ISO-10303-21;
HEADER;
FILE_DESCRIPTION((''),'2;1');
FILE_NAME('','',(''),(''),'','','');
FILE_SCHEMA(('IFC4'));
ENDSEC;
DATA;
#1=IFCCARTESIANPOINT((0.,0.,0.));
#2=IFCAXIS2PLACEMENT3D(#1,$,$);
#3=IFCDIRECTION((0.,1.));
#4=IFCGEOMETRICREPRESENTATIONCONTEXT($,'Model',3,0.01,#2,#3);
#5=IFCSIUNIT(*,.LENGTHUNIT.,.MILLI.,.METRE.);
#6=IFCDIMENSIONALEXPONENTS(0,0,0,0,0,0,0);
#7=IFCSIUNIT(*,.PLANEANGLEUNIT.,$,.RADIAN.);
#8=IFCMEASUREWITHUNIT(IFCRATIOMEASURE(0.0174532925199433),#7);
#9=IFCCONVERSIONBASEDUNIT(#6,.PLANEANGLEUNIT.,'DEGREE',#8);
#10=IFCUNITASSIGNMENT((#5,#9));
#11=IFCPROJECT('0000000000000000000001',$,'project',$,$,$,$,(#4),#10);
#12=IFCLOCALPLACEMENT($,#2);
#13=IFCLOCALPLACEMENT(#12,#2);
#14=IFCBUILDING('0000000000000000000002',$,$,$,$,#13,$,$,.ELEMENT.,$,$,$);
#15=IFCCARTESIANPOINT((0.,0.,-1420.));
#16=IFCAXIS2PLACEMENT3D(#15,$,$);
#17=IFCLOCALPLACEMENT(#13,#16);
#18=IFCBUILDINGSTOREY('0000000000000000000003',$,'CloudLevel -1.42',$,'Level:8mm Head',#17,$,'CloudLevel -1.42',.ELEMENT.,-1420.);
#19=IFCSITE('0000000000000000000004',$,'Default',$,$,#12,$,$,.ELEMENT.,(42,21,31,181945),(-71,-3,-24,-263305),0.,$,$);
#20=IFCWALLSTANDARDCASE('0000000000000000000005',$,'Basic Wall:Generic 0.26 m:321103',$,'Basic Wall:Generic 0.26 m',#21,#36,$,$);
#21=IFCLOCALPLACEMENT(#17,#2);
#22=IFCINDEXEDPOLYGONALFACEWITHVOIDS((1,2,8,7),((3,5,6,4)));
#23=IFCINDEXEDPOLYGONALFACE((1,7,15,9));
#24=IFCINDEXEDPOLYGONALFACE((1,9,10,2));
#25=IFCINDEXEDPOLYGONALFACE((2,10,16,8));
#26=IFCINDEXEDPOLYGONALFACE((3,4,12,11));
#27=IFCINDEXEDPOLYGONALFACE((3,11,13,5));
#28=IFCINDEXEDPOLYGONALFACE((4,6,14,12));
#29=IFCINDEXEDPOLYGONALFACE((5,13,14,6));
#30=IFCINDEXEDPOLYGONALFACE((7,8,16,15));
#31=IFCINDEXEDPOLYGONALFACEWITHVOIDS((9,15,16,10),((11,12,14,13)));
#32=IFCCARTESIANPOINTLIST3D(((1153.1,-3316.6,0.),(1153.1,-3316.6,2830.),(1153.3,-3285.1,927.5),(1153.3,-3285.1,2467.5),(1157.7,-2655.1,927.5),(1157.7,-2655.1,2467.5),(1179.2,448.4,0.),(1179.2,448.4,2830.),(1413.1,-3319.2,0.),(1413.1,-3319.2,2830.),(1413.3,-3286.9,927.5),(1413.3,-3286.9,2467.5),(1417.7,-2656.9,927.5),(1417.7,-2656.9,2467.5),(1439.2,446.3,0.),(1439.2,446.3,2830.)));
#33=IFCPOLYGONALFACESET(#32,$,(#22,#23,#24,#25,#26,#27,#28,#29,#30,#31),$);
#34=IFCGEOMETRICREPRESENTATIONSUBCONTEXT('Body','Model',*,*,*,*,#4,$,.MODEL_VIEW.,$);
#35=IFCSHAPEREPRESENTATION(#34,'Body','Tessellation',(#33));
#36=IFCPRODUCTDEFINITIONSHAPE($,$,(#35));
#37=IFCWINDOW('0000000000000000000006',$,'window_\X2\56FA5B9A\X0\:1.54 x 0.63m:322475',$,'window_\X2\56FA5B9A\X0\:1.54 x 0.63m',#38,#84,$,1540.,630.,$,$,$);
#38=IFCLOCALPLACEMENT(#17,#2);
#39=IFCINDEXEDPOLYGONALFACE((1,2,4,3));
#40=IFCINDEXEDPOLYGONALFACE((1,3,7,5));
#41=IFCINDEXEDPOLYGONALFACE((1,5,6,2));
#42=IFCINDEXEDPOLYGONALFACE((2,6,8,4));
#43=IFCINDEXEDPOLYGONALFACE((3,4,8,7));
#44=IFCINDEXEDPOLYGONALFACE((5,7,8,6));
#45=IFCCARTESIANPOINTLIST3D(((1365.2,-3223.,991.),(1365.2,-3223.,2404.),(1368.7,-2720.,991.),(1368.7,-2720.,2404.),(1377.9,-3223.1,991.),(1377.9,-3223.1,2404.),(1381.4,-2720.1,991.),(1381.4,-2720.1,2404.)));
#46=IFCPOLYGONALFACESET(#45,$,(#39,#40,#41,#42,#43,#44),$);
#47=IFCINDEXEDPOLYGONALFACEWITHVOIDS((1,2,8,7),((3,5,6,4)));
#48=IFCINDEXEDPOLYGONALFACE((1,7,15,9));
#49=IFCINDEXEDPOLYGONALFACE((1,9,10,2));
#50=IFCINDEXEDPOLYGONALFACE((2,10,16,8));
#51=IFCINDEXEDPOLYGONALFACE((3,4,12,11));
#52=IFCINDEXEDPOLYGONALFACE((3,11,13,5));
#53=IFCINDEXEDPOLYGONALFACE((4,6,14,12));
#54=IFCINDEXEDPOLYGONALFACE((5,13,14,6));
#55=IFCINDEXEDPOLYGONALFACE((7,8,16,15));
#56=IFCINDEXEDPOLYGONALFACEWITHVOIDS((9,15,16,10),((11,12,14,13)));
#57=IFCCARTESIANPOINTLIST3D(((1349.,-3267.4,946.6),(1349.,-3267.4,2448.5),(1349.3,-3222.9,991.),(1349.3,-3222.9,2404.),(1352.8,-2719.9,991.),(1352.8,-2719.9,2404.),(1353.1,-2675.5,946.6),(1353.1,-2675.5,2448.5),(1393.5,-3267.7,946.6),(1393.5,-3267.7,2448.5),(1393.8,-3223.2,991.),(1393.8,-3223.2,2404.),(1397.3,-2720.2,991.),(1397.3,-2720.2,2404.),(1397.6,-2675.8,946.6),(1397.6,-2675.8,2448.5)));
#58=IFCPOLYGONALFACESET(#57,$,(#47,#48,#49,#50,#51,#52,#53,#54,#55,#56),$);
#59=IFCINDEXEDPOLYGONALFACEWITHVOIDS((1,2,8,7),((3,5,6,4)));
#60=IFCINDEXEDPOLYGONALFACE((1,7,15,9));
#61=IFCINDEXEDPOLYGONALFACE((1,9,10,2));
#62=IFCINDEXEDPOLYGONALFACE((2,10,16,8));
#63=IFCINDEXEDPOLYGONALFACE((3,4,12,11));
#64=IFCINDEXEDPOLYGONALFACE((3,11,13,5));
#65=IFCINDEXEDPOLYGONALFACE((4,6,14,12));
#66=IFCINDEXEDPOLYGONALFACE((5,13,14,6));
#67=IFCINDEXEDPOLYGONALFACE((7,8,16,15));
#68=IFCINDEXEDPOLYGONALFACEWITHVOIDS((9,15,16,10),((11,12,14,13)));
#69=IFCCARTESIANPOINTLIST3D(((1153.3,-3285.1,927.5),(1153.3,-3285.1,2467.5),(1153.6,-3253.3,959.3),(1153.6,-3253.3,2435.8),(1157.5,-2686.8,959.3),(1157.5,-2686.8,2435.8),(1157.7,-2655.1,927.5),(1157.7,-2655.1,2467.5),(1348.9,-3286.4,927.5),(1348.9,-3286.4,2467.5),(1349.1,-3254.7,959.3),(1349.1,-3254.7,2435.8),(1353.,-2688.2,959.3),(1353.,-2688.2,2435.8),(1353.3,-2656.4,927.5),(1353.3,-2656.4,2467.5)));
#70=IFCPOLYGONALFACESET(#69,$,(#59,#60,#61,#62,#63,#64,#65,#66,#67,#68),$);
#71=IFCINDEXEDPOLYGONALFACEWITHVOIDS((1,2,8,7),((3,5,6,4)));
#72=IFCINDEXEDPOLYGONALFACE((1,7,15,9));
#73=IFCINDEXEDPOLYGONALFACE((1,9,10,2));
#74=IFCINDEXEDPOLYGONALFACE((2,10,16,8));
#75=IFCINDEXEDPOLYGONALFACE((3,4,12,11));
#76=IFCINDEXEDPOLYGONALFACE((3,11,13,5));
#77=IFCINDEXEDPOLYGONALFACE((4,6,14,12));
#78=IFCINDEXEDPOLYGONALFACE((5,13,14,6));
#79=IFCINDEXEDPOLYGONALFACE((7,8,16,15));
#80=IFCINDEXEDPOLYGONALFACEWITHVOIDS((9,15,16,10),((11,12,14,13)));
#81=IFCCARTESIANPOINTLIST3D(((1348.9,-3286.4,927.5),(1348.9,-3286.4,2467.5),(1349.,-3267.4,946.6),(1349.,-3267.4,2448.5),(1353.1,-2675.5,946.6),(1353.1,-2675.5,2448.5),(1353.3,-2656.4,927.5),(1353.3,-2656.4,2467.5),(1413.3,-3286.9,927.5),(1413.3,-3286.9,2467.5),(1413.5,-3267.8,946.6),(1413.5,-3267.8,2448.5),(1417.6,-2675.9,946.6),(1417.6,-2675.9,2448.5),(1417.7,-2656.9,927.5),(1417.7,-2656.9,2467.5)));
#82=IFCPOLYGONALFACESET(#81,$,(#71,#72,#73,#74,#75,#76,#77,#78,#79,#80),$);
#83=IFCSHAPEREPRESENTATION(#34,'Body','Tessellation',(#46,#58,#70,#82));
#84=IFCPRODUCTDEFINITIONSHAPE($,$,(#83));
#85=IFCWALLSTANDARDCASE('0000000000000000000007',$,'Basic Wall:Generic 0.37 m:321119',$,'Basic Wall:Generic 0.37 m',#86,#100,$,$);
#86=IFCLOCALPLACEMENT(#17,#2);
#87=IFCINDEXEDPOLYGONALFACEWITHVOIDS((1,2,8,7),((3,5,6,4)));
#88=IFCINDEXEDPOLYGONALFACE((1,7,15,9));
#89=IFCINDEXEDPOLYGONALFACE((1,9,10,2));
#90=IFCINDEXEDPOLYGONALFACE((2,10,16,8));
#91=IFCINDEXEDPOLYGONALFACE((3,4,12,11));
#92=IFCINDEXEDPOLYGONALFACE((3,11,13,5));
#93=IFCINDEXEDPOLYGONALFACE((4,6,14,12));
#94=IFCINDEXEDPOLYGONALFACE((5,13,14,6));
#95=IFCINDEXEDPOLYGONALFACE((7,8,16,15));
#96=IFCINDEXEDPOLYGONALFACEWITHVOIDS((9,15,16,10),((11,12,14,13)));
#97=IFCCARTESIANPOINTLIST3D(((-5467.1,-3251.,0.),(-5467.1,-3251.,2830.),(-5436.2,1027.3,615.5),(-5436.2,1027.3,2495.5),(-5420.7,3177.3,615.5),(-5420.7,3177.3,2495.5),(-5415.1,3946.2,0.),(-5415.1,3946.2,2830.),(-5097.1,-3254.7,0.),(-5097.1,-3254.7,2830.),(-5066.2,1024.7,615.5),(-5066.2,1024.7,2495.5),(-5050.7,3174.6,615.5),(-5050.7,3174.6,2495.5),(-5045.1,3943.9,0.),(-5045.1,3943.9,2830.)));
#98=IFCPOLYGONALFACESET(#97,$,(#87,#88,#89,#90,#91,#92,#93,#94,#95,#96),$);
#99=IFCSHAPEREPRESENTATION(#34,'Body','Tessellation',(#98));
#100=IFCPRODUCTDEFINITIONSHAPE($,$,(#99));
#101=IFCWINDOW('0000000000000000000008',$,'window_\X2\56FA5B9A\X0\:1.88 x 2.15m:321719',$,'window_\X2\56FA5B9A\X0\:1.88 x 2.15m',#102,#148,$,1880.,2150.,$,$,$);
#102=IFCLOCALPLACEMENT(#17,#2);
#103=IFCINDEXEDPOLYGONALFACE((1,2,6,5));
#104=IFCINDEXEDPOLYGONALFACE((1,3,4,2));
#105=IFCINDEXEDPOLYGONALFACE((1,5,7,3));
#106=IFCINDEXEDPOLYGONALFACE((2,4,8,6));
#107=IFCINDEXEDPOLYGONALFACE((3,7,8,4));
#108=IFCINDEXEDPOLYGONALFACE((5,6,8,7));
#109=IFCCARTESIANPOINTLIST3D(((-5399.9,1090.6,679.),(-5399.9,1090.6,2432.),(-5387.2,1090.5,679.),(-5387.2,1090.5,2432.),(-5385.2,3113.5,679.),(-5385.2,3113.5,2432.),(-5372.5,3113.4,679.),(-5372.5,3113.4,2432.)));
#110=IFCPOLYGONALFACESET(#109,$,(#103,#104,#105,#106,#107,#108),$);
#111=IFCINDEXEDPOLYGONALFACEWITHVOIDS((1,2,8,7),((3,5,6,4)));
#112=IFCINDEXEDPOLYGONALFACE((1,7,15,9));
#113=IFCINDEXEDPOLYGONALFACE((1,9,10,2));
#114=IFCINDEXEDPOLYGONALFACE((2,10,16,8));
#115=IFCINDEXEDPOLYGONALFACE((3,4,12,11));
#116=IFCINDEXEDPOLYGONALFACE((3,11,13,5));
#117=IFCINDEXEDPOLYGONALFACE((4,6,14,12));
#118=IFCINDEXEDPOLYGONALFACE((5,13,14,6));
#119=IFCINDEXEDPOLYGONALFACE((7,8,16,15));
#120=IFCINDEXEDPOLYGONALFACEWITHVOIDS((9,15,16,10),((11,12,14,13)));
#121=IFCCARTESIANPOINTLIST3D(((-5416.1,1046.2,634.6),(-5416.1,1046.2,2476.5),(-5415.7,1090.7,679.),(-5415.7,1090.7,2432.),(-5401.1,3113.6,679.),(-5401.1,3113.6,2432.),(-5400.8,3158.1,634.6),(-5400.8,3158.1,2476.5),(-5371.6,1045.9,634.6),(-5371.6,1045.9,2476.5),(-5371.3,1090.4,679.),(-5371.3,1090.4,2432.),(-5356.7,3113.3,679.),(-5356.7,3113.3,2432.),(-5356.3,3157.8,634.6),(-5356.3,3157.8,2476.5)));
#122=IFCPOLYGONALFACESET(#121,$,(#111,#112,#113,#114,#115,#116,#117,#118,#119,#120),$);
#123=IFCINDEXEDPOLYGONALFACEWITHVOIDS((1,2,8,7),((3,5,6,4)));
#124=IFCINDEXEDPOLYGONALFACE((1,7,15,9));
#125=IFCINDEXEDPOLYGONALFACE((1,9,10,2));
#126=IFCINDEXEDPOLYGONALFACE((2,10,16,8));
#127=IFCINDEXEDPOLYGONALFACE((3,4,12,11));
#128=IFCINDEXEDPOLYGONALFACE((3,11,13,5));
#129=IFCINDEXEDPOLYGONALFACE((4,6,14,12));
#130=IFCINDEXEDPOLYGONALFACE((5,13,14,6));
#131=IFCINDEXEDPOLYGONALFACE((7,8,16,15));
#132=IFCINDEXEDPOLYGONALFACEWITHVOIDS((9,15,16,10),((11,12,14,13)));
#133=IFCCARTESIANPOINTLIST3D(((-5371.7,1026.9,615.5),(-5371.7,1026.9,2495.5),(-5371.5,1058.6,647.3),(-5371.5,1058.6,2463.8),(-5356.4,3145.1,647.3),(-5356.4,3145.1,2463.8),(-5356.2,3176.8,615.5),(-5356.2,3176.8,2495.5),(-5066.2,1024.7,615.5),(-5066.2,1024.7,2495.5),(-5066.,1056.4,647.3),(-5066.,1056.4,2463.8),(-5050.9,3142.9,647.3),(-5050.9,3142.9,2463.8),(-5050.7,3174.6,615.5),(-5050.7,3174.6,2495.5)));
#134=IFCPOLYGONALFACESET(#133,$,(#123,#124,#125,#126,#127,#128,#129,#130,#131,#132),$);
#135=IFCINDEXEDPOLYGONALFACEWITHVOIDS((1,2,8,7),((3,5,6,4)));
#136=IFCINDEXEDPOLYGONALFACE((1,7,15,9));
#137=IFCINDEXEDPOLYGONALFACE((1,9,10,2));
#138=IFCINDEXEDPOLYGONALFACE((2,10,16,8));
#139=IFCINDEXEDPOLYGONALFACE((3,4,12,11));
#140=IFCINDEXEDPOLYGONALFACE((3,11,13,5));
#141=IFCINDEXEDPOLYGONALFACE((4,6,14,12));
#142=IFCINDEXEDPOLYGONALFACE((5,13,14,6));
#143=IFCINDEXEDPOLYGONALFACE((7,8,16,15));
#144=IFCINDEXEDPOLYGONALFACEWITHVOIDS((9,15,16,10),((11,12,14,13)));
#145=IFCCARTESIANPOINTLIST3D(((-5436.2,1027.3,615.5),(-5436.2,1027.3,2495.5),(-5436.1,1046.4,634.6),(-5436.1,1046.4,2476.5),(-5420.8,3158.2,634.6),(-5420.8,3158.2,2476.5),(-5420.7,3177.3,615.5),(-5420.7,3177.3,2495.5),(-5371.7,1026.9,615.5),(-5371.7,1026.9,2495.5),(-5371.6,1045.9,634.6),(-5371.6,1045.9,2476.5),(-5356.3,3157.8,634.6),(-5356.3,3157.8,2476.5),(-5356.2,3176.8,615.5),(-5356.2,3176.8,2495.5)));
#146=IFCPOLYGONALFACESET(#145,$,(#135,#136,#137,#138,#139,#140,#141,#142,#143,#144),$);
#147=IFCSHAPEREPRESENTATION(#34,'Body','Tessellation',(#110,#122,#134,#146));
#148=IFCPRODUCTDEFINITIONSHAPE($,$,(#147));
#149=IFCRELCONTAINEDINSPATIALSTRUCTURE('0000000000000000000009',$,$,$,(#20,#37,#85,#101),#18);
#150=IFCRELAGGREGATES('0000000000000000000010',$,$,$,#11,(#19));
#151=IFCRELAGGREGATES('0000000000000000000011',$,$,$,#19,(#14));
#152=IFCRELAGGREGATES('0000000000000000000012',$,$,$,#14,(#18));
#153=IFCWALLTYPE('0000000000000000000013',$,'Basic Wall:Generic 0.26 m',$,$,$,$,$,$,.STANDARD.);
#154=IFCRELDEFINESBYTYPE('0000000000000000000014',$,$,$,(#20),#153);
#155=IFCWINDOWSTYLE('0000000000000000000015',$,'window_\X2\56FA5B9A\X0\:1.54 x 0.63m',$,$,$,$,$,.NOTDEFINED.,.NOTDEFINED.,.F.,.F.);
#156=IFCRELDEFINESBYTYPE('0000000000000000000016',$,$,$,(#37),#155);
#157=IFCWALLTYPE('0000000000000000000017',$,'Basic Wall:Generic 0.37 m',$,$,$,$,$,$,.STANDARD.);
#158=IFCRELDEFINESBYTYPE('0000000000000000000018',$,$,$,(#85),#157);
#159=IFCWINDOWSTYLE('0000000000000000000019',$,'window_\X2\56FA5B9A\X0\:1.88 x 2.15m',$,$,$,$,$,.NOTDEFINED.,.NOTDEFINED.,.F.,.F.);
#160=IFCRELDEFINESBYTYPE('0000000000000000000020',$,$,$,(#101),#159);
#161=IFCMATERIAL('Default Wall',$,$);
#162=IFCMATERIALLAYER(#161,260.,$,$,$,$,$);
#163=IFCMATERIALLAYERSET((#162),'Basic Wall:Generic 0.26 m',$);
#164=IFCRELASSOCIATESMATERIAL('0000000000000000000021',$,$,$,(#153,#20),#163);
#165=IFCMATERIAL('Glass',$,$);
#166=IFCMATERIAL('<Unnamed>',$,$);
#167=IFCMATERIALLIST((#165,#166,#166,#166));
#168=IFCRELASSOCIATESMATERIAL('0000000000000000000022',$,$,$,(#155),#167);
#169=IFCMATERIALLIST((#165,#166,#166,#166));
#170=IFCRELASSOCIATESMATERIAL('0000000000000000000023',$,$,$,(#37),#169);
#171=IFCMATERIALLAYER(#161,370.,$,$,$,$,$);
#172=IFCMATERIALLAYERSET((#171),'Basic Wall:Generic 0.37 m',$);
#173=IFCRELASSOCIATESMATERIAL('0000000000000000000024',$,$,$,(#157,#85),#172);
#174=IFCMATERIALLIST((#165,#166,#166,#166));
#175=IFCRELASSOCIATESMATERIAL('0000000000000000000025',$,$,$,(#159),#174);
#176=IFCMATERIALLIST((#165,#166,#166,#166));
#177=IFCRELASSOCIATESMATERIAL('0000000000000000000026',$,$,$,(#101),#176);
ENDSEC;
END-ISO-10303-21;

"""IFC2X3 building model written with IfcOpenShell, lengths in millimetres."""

from ifc_helpers import new_model, entity, si_unit, converted_unit, direction, frame, frame_2d, origin, origin_2d_with_axis, place, context, subcontext, project, spatial, polyline, rectangle, outline, extrude, source, transform, mapped, material, material_list, layer, layer_set, layer_usage, type_object, type_shapes, element, fill, save


model = new_model("IFC2X3")

# Units and contexts
model_context = context("Model", 3, precision=0.01, world=origin(), true_north=direction((0.0, 1.0)))
body_context = subcontext(model_context, "Body", "Model", "MODEL_VIEW")
ifc_project = project(units=[si_unit("LENGTHUNIT", "METRE", prefix="MILLI"), converted_unit("PLANEANGLEUNIT", "DEGREE", entity("IfcRatioMeasure", 0.0174532925199433), si_unit("PLANEANGLEUNIT", "RADIAN"), dimensions=[0, 0, 0, 0, 0, 0, 0])], contexts=[model_context])

# Site, building, storey
site_placement = place(None, origin())
site = spatial("IfcSite", under=ifc_project, at=site_placement, Name="Default", CompositionType="ELEMENT", RefLatitude=(42, 21, 31, 181945), RefLongitude=(-71, -3, -24, -263305), RefElevation=0.0)
building_placement = place(site_placement, origin())
building = spatial("IfcBuilding", under=site, at=building_placement, CompositionType="ELEMENT")
storey_placement = place(building_placement, frame((0.0, 0.0, -1420.0)))
storey = spatial("IfcBuildingStorey", under=building, at=storey_placement, Name="CloudLevel -1.42", ObjectType="Level:8mm Head", LongName="CloudLevel -1.42", CompositionType="ELEMENT", Elevation=-1420.0)

# Shared definitions
ifc_material_1 = material(Name="Default Wall")
ifc_material_2 = material(Name="Glass")
ifc_material_3 = material(Name="<Unnamed>")

# Walls, openings, windows
ifc_layer_1 = layer(ifc_material_1, 260.0)
ifc_layer_set_1 = layer_set([ifc_layer_1], Name="Basic Wall:Generic 0.26 m")
ifc_layer_usage_1 = layer_usage(ifc_layer_set_1, "AXIS2", "NEGATIVE", 130.0)
wall_type_1 = type_object("IfcWallType", Name="Basic Wall:Generic 0.26 m", PredefinedType="STANDARD", material=ifc_layer_set_1)
wall_1_placement = place(storey_placement, frame((1283.1, -3318.3, 0.0), z_axis=(0.0, 0.0, 1.0), x_axis=(0.006925, 0.999976, 0.0)))
wall_1 = element("IfcWallStandardCase", 1, at=wall_1_placement, inside=storey, type_object=wall_type_1, material=ifc_layer_usage_1, Name="Basic Wall:Generic 0.26 m:321103", ObjectType="Basic Wall:Generic 0.26 m", context=body_context, shape_type="SweptSolid", body=[
    extrude(outline(polyline([(3765.5, -130.0), (3765.9, 130.0), (0.8, 130.0), (0.0, -130.0), (902.2, -130.0), (1142.2, -130.0), (3765.5, -130.0)])), origin(), (0.0, 0.0, 1.0), 2830.0),
])
opening_1_placement = place(wall_1_placement, frame((662.3, 130.0, 927.5)))
opening_1 = element("IfcOpeningElement", 2, at=opening_1_placement, cuts=wall_1, ObjectType="Opening", context=body_context, shape_type="SweptSolid", body=[
    extrude(rectangle(XDim=1540.0, YDim=630.0, at=frame_2d((770.0, 315.0), x_axis=(-1.0, 0.0))), frame((0.0, 0.0, 0.0), z_axis=(0.0, -1.0, 0.0), x_axis=(0.0, 0.0, 1.0)), (0.0, 0.0, 1.0), 260.0),
])
ifc_material_list_1 = material_list([ifc_material_2, ifc_material_3, ifc_material_3, ifc_material_3])
ifc_material_list_2 = material_list([ifc_material_2, ifc_material_3, ifc_material_3, ifc_material_3])
window_style_1 = type_object("IfcWindowStyle", Name="window_固定:1.54 x 0.63m", ConstructionType="NOTDEFINED", OperationType="NOTDEFINED", ParameterTakesPrecedence=False, Sizeable=False, material=ifc_material_list_2)
shared_shape_1 = source(origin(), body_context, "Body", "SweptSolid", [
    extrude(rectangle(XDim=503.0, YDim=12.7, at=origin_2d_with_axis()), frame((391.2, 217.8, 63.5)), (0.0, 0.0, 1.0), 1413.0),
    extrude(outline(polyline([(-295.9, -750.9), (295.9, -750.9), (295.9, 750.9), (-295.9, 750.9), (-295.9, -750.9)]), holes=[polyline([(-251.5, -706.5), (-251.5, 706.5), (251.5, 706.5), (251.5, -706.5), (-251.5, -706.5)])]), frame((391.2, 240.0, 770.0), z_axis=(0.0, -1.0, 0.0), x_axis=(-1.0, 0.0, 0.0)), (0.0, 0.0, 1.0), 44.5),
    extrude(outline(polyline([(-315.0, -770.0), (315.0, -770.0), (315.0, 770.0), (-315.0, 770.0), (-315.0, -770.0)]), holes=[polyline([(-283.2, -738.2), (-283.2, 738.2), (283.2, 738.2), (283.2, -738.2), (-283.2, -738.2)])]), frame((391.2, 195.5, 770.0), z_axis=(0.0, -1.0, 0.0), x_axis=(-1.0, 0.0, 0.0)), (0.0, 0.0, 1.0), 195.5),
    extrude(outline(polyline([(-770.0, -315.0), (770.0, -315.0), (770.0, 315.0), (-770.0, 315.0), (-770.0, -315.0)]), holes=[polyline([(-750.9, -295.9), (-750.9, 295.9), (750.9, 295.9), (750.9, -295.9), (-750.9, -295.9)])]), frame((391.2, 260.0, 770.0), z_axis=(0.0, -1.0, 0.0), x_axis=(0.0, 0.0, -1.0)), (0.0, 0.0, 1.0), 64.5),
])
type_shapes(window_style_1, [shared_shape_1])
window_1_placement = place(opening_1_placement, frame((76.2, 0.0, 0.0), z_axis=(0.0, 0.0, 1.0), x_axis=(-1.0, 0.0, 0.0)))
window_1 = element("IfcWindow", 3, at=window_1_placement, inside=storey, type_object=window_style_1, material=ifc_material_list_1, Name="window_固定:1.54 x 0.63m:322475", ObjectType="window_固定:1.54 x 0.63m", OverallHeight=1540.0, OverallWidth=630.0, context=body_context, shape_type="MappedRepresentation", body=[
    mapped(shared_shape_1, transform((0.0, 0.0, 0.0), scale=1.0)),
])
fill(opening_1, window_1)
ifc_layer_2 = layer(ifc_material_1, 370.0)
ifc_layer_set_2 = layer_set([ifc_layer_2], Name="Basic Wall:Generic 0.37 m")
ifc_layer_usage_2 = layer_usage(ifc_layer_set_2, "AXIS2", "NEGATIVE", 185.0)
wall_type_2 = type_object("IfcWallType", Name="Basic Wall:Generic 0.37 m", PredefinedType="STANDARD", material=ifc_layer_set_2)
wall_2_placement = place(storey_placement, frame((-5230.1, 3945.3, 0.0), z_axis=(0.0, 0.0, 1.0), x_axis=(-0.007227, -0.999974, 0.0)))
wall_2 = element("IfcWallStandardCase", 4, at=wall_2_placement, inside=storey, type_object=wall_type_2, material=ifc_layer_usage_2, Name="Basic Wall:Generic 0.37 m:321119", ObjectType="Basic Wall:Generic 0.37 m", context=body_context, shape_type="SweptSolid", body=[
    extrude(outline(polyline([(7197.8, -185.0), (7198.8, 185.0), (240.0, 185.0), (0.0, 185.0), (0.4, -185.0), (3170.3, -185.0), (3410.3, -185.0), (7197.8, -185.0)])), origin(), (0.0, 0.0, 1.0), 2830.0),
])
opening_2_placement = place(wall_2_placement, frame((2919.3, 185.0, 615.5)))
opening_2 = element("IfcOpeningElement", 5, at=opening_2_placement, cuts=wall_2, ObjectType="Opening", context=body_context, shape_type="SweptSolid", body=[
    extrude(rectangle(XDim=1880.0, YDim=2150.0, at=frame_2d((940.0, 1075.0), x_axis=(-1.0, 0.0))), frame((0.0, 0.0, 0.0), z_axis=(0.0, -1.0, 0.0), x_axis=(0.0, 0.0, 1.0)), (0.0, 0.0, 1.0), 370.0),
])
ifc_material_list_3 = material_list([ifc_material_2, ifc_material_3, ifc_material_3, ifc_material_3])
ifc_material_list_4 = material_list([ifc_material_2, ifc_material_3, ifc_material_3, ifc_material_3])
window_style_2 = type_object("IfcWindowStyle", Name="window_固定:1.88 x 2.15m", ConstructionType="NOTDEFINED", OperationType="NOTDEFINED", ParameterTakesPrecedence=False, Sizeable=False, material=ifc_material_list_4)
shared_shape_2 = source(origin(), body_context, "Body", "SweptSolid", [
    extrude(rectangle(XDim=2023.0, YDim=12.7, at=frame_2d((0.0, 0.0), x_axis=(1.0, 0.0))), frame((1151.2, 327.8, 63.5)), (0.0, 0.0, 1.0), 1753.0),
    extrude(outline(polyline([(-1055.9, -920.9), (1055.9, -920.9), (1055.9, 920.9), (-1055.9, 920.9), (-1055.9, -920.9)]), holes=[polyline([(-1011.5, -876.5), (-1011.5, 876.5), (1011.5, 876.5), (1011.5, -876.5), (-1011.5, -876.5)])]), frame((1151.2, 350.0, 940.0), z_axis=(0.0, -1.0, 0.0), x_axis=(-1.0, 0.0, 0.0)), (0.0, 0.0, 1.0), 44.5),
    extrude(outline(polyline([(-1075.0, -940.0), (1075.0, -940.0), (1075.0, 940.0), (-1075.0, 940.0), (-1075.0, -940.0)]), holes=[polyline([(-1043.2, -908.2), (-1043.2, 908.2), (1043.2, 908.2), (1043.2, -908.2), (-1043.2, -908.2)])]), frame((1151.2, 305.5, 940.0), z_axis=(0.0, -1.0, 0.0), x_axis=(-1.0, 0.0, 0.0)), (0.0, 0.0, 1.0), 305.5),
    extrude(outline(polyline([(-940.0, -1075.0), (940.0, -1075.0), (940.0, 1075.0), (-940.0, 1075.0), (-940.0, -1075.0)]), holes=[polyline([(-920.9, -1055.9), (-920.9, 1055.9), (920.9, 1055.9), (920.9, -1055.9), (-920.9, -1055.9)])]), frame((1151.2, 370.0, 940.0), z_axis=(0.0, -1.0, 0.0), x_axis=(0.0, 0.0, -1.0)), (0.0, 0.0, 1.0), 64.5),
])
type_shapes(window_style_2, [shared_shape_2])
window_2_placement = place(opening_2_placement, frame((76.2, 0.0, 0.0), z_axis=(0.0, 0.0, 1.0), x_axis=(-1.0, 0.0, 0.0)))
window_2 = element("IfcWindow", 6, at=window_2_placement, inside=storey, type_object=window_style_2, material=ifc_material_list_3, Name="window_固定:1.88 x 2.15m:321719", ObjectType="window_固定:1.88 x 2.15m", OverallHeight=1880.0, OverallWidth=2150.0, context=body_context, shape_type="MappedRepresentation", body=[
    mapped(shared_shape_2, transform((0.0, 0.0, 0.0), scale=1.0)),
])
fill(opening_2, window_2)

save(model, "model.ifc")
